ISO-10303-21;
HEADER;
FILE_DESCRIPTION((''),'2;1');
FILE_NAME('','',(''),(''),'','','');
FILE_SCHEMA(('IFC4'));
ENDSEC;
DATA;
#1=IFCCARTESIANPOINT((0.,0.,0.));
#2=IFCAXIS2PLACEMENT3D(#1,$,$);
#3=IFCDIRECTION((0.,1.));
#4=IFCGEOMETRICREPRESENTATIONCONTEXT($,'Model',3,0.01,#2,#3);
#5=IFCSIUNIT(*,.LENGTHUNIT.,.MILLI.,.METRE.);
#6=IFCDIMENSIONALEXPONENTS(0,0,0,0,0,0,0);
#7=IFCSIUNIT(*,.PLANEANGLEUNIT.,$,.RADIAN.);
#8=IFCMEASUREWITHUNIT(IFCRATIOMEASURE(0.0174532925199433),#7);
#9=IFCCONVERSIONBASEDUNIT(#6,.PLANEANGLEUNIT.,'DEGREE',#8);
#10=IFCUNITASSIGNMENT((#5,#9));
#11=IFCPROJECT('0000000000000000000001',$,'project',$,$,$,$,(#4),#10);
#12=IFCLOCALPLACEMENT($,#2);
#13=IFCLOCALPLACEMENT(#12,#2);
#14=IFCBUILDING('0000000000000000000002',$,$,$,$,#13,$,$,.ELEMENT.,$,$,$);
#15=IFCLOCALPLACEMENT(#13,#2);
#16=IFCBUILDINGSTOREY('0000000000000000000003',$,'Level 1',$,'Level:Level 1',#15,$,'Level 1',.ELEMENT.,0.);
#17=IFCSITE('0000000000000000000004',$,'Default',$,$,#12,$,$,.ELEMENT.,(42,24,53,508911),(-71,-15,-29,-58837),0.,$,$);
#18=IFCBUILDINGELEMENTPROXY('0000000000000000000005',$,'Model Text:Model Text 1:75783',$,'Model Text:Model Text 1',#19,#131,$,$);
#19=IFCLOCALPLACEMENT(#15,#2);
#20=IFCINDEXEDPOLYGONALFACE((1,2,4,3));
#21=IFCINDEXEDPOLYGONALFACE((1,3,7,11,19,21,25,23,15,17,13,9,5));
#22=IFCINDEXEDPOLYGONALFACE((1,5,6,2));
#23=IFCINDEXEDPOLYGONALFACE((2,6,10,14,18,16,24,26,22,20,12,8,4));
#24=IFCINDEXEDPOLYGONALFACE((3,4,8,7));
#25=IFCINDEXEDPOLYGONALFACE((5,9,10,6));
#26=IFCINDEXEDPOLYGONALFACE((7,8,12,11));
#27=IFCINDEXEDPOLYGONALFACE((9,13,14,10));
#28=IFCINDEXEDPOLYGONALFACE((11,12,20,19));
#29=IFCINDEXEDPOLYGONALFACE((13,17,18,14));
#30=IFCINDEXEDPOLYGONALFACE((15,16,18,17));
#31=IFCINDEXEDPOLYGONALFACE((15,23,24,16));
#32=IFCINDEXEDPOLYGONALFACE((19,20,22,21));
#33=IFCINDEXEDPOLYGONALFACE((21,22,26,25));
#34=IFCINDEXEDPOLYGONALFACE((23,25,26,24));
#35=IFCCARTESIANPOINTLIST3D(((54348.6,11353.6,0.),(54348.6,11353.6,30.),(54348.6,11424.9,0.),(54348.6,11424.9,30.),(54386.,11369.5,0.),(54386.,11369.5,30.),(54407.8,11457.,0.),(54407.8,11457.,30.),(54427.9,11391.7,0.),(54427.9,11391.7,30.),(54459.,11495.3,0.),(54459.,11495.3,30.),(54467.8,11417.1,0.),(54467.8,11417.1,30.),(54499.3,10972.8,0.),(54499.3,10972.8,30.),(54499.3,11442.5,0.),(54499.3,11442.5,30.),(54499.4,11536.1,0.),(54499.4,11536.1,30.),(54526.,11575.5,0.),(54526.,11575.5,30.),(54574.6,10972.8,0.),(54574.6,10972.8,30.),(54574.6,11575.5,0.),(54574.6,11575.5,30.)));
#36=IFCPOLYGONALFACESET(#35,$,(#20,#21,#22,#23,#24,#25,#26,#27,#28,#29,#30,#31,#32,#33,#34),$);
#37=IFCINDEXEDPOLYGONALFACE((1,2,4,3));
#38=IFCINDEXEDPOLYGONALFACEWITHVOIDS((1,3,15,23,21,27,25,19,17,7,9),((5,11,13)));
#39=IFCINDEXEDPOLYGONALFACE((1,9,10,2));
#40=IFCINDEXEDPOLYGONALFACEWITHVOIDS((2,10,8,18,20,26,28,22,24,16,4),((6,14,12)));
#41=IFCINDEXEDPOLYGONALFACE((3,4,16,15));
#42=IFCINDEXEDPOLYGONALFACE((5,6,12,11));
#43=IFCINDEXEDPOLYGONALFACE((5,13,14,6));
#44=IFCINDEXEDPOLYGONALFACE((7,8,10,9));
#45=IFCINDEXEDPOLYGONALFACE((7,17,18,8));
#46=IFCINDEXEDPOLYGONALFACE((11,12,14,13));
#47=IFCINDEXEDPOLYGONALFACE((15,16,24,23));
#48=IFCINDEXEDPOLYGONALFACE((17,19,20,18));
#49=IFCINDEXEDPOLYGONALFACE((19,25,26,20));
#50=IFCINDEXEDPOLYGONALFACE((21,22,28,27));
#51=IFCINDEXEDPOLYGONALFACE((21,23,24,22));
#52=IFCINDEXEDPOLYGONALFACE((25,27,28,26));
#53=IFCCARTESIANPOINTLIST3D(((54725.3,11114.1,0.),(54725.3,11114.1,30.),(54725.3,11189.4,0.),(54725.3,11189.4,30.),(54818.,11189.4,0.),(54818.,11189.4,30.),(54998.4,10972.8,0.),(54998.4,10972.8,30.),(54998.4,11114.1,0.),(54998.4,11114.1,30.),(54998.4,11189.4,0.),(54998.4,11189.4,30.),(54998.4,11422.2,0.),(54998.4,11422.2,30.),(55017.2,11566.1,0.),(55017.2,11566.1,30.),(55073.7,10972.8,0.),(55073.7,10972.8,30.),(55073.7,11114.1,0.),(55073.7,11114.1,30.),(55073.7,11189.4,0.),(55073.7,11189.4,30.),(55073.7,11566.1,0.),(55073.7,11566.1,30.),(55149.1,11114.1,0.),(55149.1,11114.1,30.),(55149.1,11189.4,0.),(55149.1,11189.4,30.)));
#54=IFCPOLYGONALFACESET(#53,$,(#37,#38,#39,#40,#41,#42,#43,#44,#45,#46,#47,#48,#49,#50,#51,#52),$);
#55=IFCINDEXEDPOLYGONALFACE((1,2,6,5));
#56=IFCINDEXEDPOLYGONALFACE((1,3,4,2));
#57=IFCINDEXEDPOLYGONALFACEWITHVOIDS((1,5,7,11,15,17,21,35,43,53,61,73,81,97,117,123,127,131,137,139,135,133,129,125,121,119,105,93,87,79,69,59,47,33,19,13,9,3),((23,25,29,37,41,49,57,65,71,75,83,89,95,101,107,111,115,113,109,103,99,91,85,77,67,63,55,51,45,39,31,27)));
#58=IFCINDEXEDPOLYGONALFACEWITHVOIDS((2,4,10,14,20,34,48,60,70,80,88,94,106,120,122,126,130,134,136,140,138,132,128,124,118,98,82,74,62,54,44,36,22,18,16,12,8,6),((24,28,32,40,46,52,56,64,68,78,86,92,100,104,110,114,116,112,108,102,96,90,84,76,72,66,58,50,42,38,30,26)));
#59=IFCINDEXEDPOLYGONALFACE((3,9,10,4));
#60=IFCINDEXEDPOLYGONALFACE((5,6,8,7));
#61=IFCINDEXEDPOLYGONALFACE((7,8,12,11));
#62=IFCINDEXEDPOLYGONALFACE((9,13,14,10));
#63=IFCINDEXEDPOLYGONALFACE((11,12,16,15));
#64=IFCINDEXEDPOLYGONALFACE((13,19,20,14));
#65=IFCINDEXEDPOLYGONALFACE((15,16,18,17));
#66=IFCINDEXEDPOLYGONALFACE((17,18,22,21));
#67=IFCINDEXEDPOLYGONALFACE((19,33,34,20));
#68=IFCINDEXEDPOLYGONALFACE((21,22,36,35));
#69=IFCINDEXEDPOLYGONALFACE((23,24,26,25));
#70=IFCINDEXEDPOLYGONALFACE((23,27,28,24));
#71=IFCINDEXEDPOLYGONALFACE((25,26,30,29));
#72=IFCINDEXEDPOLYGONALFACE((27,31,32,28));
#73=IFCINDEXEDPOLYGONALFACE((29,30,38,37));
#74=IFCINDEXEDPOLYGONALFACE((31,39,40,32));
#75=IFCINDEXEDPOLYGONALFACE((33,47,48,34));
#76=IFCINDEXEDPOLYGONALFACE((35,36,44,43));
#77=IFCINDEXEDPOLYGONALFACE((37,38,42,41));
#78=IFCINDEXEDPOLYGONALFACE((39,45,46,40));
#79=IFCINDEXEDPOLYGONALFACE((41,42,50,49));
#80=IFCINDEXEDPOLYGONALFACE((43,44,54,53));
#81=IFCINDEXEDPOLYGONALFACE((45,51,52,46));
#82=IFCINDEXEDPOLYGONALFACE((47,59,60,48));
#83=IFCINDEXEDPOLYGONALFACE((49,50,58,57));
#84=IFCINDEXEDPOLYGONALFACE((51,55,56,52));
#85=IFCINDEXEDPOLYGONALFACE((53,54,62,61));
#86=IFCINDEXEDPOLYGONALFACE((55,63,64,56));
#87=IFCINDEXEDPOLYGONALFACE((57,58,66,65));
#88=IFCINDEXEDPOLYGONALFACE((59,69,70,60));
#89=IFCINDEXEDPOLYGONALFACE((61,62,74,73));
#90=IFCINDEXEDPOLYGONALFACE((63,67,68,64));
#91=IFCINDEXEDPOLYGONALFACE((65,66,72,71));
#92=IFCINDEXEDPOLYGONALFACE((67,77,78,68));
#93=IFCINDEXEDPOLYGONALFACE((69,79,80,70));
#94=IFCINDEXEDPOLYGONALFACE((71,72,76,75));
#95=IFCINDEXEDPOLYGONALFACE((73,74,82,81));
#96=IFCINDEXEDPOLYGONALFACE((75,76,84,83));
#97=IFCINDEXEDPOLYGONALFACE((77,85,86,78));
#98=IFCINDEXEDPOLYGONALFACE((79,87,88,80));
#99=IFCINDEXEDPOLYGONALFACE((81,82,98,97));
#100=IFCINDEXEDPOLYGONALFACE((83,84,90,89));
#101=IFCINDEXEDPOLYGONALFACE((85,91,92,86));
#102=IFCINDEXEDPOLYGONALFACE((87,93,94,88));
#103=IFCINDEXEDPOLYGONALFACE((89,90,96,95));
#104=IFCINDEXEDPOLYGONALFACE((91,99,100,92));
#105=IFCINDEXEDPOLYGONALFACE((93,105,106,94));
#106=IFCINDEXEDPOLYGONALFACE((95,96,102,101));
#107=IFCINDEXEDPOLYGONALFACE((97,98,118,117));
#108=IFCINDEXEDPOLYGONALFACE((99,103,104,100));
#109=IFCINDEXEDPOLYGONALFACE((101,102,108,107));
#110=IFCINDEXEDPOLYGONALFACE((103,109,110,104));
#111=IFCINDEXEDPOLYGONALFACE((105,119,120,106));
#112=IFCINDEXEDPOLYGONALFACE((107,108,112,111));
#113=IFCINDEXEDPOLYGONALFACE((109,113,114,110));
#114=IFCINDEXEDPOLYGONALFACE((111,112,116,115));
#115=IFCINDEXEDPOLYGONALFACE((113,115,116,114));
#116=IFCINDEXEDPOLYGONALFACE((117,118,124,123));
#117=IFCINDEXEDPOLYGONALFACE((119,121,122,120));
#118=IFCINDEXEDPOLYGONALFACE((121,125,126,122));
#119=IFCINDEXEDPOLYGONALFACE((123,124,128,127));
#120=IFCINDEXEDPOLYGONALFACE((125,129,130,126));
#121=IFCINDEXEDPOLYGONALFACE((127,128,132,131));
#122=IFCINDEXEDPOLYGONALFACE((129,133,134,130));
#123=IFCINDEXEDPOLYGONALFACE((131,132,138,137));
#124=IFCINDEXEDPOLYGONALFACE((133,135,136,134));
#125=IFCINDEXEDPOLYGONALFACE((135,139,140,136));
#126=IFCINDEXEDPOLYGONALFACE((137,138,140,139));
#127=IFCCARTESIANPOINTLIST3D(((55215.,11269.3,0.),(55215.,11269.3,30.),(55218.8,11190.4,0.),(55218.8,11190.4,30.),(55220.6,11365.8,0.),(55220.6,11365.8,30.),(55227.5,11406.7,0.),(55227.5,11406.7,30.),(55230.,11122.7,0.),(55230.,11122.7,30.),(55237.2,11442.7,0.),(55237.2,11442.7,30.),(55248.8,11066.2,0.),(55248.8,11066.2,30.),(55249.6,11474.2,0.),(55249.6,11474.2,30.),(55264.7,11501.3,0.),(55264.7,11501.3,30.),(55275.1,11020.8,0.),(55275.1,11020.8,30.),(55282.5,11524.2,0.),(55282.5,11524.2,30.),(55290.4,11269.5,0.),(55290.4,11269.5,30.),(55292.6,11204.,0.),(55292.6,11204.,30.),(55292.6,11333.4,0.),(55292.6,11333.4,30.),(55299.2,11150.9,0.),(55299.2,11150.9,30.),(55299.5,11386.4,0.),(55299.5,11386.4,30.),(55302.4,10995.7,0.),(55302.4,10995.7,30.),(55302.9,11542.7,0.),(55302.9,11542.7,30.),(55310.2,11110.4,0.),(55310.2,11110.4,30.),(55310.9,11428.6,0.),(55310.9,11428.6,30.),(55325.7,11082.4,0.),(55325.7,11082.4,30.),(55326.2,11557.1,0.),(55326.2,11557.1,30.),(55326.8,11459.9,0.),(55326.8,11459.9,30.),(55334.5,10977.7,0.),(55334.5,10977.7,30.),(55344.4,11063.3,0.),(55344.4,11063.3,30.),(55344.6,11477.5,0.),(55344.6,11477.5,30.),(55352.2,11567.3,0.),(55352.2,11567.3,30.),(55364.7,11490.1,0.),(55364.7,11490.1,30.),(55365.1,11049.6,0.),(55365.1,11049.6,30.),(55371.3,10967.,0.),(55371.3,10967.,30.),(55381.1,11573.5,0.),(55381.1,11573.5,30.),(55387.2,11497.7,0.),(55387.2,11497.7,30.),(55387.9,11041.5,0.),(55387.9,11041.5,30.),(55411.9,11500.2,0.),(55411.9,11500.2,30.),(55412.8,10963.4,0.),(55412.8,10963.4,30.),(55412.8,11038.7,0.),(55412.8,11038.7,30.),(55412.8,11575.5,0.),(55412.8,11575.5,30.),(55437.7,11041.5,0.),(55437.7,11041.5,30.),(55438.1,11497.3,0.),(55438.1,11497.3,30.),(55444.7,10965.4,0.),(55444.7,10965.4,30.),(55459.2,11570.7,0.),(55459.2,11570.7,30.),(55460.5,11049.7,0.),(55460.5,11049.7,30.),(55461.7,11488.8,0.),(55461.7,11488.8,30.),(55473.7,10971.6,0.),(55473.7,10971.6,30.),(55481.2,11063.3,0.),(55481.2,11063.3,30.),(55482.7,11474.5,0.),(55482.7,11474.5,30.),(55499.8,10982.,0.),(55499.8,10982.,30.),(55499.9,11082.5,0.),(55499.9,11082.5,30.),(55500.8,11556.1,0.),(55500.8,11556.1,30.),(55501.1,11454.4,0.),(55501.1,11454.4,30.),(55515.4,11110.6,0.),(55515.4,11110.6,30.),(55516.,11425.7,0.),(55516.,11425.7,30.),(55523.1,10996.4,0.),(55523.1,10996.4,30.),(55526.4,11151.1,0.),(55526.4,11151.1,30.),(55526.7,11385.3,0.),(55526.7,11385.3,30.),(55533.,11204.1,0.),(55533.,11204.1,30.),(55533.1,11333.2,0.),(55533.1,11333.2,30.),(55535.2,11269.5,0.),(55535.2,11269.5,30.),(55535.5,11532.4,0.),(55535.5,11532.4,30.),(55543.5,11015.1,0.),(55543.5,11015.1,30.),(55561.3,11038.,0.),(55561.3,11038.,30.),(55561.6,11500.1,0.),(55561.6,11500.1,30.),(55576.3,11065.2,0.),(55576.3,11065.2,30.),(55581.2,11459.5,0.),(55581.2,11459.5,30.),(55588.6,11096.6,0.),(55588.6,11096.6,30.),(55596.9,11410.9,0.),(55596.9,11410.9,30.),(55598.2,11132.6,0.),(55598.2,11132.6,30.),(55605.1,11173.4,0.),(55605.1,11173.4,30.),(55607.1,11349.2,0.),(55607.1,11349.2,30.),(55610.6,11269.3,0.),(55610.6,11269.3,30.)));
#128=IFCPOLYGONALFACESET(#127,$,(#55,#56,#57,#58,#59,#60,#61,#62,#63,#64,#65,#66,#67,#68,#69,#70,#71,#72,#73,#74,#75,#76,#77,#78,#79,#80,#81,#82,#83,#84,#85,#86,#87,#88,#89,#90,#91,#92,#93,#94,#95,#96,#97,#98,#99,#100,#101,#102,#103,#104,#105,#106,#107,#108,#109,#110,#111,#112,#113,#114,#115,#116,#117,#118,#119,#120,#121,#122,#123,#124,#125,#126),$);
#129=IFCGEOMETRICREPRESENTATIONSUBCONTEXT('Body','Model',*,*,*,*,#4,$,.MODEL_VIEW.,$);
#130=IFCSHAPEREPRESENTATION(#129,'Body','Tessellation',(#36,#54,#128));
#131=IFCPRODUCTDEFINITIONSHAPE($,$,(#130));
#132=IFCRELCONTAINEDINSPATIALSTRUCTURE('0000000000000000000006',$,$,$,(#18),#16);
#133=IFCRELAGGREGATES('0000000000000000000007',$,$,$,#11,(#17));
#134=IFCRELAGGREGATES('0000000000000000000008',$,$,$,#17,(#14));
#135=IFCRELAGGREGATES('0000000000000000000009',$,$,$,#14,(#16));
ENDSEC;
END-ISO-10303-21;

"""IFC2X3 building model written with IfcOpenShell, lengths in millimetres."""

from ifc_helpers import new_model, entity, si_unit, converted_unit, direction, frame, origin, place, context, subcontext, project, spatial, polyline, outline, extrude, element, save


model = new_model("IFC2X3")

# Units and contexts
model_context = context("Model", 3, precision=0.01, world=origin(), true_north=direction((0.0, 1.0)))
body_context = subcontext(model_context, "Body", "Model", "MODEL_VIEW")
ifc_project = project(units=[si_unit("LENGTHUNIT", "METRE", prefix="MILLI"), converted_unit("PLANEANGLEUNIT", "DEGREE", entity("IfcRatioMeasure", 0.0174532925199433), si_unit("PLANEANGLEUNIT", "RADIAN"), dimensions=[0, 0, 0, 0, 0, 0, 0])], contexts=[model_context])

# Site, building, storey
site_placement = place(None, origin())
site = spatial("IfcSite", under=ifc_project, at=site_placement, Name="Default", CompositionType="ELEMENT", RefLatitude=(42, 24, 53, 508911), RefLongitude=(-71, -15, -29, -58837), RefElevation=0.0)
building_placement = place(site_placement, origin())
building = spatial("IfcBuilding", under=site, at=building_placement, CompositionType="ELEMENT")
storey_placement = place(building_placement, origin())
storey = spatial("IfcBuildingStorey", under=building, at=storey_placement, Name="Level 1", ObjectType="Level:Level 1", LongName="Level 1", CompositionType="ELEMENT", Elevation=0.0)

# Building element proxy
proxy_1_placement = place(storey_placement, origin())
element("IfcBuildingElementProxy", 1, at=proxy_1_placement, inside=storey, Name="Model Text:Model Text 1:75783", ObjectType="Model Text:Model Text 1", context=body_context, shape_type="SweptSolid", body=[
    extrude(outline(polyline([(-410.6, -111.6), (192.1, -111.6), (192.1, -63.1), (152.7, -36.4), (111.9, 4.0), (73.6, 55.2), (41.4, 114.4), (-29.8, 114.4), (-13.9, 77.0), (8.3, 35.1), (33.7, -4.8), (59.1, -36.3), (-410.6, -36.3), (-410.6, -111.6)])), frame((54463.0, 11383.4, 0.0), z_axis=(0.0, 0.0, 1.0), x_axis=(0.0, 1.0, 0.0)), (0.0, 0.0, 1.0), 30.0),
    extrude(outline(polyline([(-6.8, -218.3), (68.5, -218.3), (68.5, -77.1), (143.8, -77.1), (143.8, -1.7), (68.5, -1.7), (68.5, 375.0), (12.0, 375.0), (-280.0, -1.7), (-280.0, -77.1), (-6.8, -77.1), (-6.8, -218.3)]), holes=[polyline([(-6.8, -1.7), (-187.3, -1.7), (-6.8, 231.1), (-6.8, -1.7)])]), frame((55005.3, 11191.1, 0.0)), (0.0, 0.0, 1.0), 30.0),
    extrude(outline(polyline([(-10.6, -198.7), (68.3, -198.7), (136.5, -190.7), (193.9, -174.7), (240.5, -150.6), (266.9, -124.4), (286.3, -93.2), (298.8, -57.0), (304.3, -15.7), (303.8, 16.2), (299.0, 45.5), (289.9, 72.1), (276.6, 96.0), (258.9, 117.3), (236.9, 136.2), (210.4, 152.5), (179.6, 166.3), (144.1, 177.6), (103.7, 186.3), (8.2, 196.4), (-71.8, 196.7), (-134.0, 189.4), (-183.3, 176.1), (-224.7, 158.4), (-258.2, 133.9), (-283.5, 100.3), (-300.1, 59.5), (-307.1, 13.4), (-306.6, -18.4), (-301.8, -47.5), (-292.8, -74.0), (-279.6, -97.9), (-262.0, -119.2), (-240.0, -138.1), (-213.6, -154.5), (-182.8, -168.4), (-147.3, -179.8), (-106.7, -188.6), (-10.6, -198.7)]), holes=[polyline([(-7.2, -123.5), (-71.0, -118.2), (-123.6, -108.8), (-165.2, -95.4), (-195.7, -78.0), (-212.4, -59.4), (-224.1, -38.7), (-230.6, -15.9), (-231.9, 8.9), (-227.8, 35.0), (-218.1, 58.1), (-202.8, 78.4), (-182.0, 95.8), (-152.6, 109.4), (-111.7, 118.1), (-59.4, 122.0), (4.4, 121.1), (69.6, 115.8), (122.2, 106.7), (162.2, 93.7), (189.5, 77.0), (207.7, 57.4), (220.4, 36.0), (227.5, 12.8), (229.1, -12.1), (225.2, -36.8), (215.9, -59.2), (201.3, -79.3), (181.4, -97.1), (152.6, -111.2), (111.6, -120.3), (58.3, -124.4), (-7.2, -123.5)])]), frame((55414.0, 11268.1, 0.0), z_axis=(0.0, 0.0, 1.0), x_axis=(0.047515, -0.998871, 0.0)), (0.0, 0.0, 1.0), 30.0),
])

save(model, "model.ifc")
